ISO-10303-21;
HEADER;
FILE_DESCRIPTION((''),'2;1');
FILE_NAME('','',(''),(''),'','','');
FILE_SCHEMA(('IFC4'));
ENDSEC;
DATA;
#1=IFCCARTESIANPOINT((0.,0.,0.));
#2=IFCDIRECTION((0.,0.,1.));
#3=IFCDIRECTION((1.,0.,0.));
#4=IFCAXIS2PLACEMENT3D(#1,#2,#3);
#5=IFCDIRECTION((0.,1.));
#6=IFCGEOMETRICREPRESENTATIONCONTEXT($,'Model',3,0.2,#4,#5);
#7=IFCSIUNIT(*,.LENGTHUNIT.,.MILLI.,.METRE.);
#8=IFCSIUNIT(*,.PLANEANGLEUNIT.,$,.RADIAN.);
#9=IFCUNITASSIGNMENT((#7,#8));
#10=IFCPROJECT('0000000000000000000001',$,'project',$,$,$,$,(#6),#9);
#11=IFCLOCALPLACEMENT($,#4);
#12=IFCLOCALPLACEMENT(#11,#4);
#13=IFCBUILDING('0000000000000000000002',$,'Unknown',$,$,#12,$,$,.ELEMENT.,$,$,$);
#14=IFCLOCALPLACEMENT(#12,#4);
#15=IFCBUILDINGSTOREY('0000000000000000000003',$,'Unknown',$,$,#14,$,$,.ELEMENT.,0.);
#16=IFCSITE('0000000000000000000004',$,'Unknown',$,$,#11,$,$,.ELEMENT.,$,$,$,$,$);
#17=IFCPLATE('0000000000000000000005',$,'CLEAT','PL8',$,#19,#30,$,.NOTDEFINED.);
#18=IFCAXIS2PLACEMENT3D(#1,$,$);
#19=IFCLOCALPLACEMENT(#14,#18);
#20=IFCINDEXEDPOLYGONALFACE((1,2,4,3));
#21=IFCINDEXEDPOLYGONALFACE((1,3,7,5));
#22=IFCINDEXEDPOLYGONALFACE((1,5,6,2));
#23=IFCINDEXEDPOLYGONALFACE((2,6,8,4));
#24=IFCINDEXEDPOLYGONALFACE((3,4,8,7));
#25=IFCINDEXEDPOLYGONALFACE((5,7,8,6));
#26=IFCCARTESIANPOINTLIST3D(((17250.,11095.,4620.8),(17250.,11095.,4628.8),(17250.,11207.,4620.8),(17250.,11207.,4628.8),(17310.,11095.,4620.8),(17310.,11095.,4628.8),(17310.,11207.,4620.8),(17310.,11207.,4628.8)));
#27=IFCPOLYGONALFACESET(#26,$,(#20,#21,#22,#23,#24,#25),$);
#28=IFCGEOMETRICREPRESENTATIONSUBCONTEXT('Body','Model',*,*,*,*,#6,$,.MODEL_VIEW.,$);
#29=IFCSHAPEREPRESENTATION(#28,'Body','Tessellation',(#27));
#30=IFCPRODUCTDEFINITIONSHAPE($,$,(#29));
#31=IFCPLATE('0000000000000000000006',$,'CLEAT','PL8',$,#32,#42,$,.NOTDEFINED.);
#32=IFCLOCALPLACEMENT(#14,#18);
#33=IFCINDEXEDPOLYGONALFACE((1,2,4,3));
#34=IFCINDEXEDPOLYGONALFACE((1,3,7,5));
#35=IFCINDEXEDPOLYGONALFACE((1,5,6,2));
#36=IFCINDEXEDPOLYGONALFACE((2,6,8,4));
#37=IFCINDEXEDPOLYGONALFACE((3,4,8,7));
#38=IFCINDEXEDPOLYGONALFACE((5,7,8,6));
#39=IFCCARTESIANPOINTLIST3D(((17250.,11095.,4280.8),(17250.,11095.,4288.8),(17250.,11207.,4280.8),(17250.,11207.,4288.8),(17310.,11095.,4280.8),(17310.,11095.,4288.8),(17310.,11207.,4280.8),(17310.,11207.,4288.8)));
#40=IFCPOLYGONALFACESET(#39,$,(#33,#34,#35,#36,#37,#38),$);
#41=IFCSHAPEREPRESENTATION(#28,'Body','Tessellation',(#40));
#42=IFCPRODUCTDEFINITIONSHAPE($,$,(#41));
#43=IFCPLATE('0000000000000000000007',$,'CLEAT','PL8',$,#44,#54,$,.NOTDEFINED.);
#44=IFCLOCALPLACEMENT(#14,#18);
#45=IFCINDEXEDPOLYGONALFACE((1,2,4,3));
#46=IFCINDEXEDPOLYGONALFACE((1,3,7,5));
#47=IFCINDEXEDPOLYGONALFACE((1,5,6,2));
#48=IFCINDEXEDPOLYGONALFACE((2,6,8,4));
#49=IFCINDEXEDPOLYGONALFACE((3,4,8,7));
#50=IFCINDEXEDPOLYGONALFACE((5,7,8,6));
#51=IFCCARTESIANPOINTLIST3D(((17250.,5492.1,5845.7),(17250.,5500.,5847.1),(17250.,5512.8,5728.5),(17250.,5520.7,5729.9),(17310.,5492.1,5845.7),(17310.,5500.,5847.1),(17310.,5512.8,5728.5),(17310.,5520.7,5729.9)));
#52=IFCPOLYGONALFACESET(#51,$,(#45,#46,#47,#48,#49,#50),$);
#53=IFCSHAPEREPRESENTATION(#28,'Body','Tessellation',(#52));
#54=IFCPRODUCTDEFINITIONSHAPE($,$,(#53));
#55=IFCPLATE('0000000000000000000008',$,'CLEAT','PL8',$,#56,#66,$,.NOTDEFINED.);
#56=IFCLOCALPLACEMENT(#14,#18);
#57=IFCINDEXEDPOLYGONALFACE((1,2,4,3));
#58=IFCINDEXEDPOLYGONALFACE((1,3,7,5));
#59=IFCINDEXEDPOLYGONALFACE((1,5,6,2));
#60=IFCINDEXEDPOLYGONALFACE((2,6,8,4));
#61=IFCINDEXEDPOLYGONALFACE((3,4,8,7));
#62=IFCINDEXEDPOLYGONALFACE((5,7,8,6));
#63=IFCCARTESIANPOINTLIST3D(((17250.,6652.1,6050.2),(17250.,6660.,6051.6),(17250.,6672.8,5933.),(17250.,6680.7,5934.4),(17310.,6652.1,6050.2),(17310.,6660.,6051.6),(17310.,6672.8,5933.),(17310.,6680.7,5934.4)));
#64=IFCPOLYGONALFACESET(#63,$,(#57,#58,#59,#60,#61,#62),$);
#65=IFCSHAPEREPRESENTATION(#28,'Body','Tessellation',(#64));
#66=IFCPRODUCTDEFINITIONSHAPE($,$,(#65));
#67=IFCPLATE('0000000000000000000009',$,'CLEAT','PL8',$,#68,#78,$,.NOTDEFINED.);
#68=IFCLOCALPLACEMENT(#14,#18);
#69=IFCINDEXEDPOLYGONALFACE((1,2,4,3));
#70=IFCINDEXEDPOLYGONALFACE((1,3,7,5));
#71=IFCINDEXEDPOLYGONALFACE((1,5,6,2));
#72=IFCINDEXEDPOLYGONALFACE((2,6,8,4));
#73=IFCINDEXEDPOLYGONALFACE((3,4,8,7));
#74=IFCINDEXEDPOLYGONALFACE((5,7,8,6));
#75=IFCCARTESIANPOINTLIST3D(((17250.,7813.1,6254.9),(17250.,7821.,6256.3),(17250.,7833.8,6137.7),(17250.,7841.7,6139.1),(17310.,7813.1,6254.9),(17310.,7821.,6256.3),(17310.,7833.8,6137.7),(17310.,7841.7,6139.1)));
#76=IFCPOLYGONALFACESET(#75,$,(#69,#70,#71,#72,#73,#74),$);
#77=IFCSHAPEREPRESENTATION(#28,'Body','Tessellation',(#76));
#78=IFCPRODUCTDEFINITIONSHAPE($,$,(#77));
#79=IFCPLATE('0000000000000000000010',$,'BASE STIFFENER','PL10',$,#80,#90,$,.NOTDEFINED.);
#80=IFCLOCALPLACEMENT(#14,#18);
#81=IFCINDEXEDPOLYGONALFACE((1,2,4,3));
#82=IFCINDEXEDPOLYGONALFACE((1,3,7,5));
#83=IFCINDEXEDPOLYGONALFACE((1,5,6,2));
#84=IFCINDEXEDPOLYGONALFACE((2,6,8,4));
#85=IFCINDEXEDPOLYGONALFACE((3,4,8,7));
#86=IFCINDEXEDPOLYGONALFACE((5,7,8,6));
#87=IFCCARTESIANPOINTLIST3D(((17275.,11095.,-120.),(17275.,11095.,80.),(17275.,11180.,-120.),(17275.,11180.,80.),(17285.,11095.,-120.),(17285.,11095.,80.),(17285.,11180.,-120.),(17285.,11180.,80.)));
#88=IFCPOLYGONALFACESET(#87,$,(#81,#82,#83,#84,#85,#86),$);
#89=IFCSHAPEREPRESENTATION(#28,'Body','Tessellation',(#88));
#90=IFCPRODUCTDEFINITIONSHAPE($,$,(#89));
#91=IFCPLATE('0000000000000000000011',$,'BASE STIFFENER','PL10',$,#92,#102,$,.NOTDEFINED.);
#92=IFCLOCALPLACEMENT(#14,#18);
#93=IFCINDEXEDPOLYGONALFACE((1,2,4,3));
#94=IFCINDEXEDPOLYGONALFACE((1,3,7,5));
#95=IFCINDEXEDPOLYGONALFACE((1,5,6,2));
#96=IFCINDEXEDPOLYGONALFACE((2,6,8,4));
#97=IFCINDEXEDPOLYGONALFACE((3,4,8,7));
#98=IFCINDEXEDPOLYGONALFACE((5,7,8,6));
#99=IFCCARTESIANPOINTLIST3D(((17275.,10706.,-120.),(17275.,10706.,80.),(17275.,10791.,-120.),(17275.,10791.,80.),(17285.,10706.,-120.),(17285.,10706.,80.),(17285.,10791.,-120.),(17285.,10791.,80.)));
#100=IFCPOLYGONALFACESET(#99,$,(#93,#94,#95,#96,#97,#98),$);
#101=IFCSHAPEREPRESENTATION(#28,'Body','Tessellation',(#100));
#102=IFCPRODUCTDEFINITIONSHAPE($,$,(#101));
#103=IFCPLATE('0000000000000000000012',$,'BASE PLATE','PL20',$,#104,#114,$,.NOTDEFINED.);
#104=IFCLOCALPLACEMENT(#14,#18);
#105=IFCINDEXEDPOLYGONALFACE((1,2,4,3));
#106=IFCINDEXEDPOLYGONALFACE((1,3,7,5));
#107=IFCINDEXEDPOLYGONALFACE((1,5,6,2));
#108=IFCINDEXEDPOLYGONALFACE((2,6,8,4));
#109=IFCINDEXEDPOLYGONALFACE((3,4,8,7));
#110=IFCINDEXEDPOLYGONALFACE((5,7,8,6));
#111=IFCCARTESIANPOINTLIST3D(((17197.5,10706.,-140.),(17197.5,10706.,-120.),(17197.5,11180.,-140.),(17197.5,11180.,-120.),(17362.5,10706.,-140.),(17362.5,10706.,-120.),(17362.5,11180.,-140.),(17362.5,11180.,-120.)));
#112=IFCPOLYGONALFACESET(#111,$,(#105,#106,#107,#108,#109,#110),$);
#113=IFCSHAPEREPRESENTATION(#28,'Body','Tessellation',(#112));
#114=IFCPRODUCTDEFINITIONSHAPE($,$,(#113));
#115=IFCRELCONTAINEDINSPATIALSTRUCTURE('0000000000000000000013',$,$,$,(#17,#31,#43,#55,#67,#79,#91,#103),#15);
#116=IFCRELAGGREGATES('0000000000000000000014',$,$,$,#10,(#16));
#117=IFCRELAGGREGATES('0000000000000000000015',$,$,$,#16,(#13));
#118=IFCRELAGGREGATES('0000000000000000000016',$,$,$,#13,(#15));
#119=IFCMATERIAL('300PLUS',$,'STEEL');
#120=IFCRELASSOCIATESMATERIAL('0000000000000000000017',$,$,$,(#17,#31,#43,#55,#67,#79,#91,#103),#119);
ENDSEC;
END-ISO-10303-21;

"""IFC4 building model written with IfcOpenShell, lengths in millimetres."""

from ifc_helpers import new_model, si_unit, direction, frame, origin_with_axes, place, context, subcontext, project, spatial, line, indexed_curve, outline, extrude, material, element, save


model = new_model("IFC4")

# Units and contexts
model_context = context("Model", 3, precision=0.2, world=origin_with_axes(), true_north=direction((0.0, 1.0)))
body_context = subcontext(model_context, "Body", "Model", "MODEL_VIEW")
ifc_project = project(units=[si_unit("LENGTHUNIT", "METRE", prefix="MILLI"), si_unit("PLANEANGLEUNIT", "RADIAN")], contexts=[model_context])

# Site, building, storey
site_placement = place(None, origin_with_axes())
site = spatial("IfcSite", under=ifc_project, at=site_placement, Name="Unknown", CompositionType="ELEMENT")
building_placement = place(site_placement, origin_with_axes())
building = spatial("IfcBuilding", under=site, at=building_placement, Name="Unknown", CompositionType="ELEMENT")
storey_placement = place(building_placement, origin_with_axes())
storey = spatial("IfcBuildingStorey", under=building, at=storey_placement, Name="Unknown", CompositionType="ELEMENT", Elevation=0.0)

# Shared definitions
ifc_material_1 = material(Name="300PLUS", Category="STEEL")

# Plates
for number, where, z_axis, x_axis, name in (
    (1, (17250.0, 11095.0, 4624.8), (0.0, 0.0, 1.0), (1.0, 0.0, 0.0), "CLEAT"),
    (2, (17250.0, 11095.0, 4284.8), (0.0, 0.0, 1.0), (1.0, 0.0, 0.0), "CLEAT"),
):
    element("IfcPlate", number, at=place(storey_placement, frame(where, z_axis=z_axis, x_axis=x_axis)), inside=storey, material=ifc_material_1, Name=name, Description="PL8", PredefinedType="NOTDEFINED", context=body_context, shape_type="SolidModel", body=[
        extrude(outline(indexed_curve([(0.0, 0.0), (60.0, 0.0), (60.0, 112.0), (0.0, 112.0)], segments=[line(1, 2, 3, 4, 1)])), frame((0.0, 0.0, 4.0), z_axis=(0.0, 0.0, 1.0), x_axis=(1.0, 0.0, 0.0)), (0.0, 0.0, -1.0), 8.0),
    ])
for number, where, z_axis, x_axis, name in (
    (3, (17310.0, 5516.7, 5729.2), (0.0, 0.984758, 0.173929), (-1.0, 0.0, 0.0), "CLEAT"),
    (4, (17310.0, 6676.7, 5933.7), (0.0, 0.984758, 0.173929), (-1.0, 0.0, 0.0), "CLEAT"),
    (5, (17310.0, 7837.7, 6138.4), (0.0, 0.984758, 0.173929), (-1.0, 0.0, 0.0), "CLEAT"),
):
    element("IfcPlate", number, at=place(storey_placement, frame(where, z_axis=z_axis, x_axis=x_axis)), inside=storey, material=ifc_material_1, Name=name, Description="PL8", PredefinedType="NOTDEFINED", context=body_context, shape_type="SolidModel", body=[
        extrude(outline(indexed_curve([(0.0, 0.0), (60.0, 0.0), (60.0, 119.0), (0.0, 119.0)], segments=[line(1, 2, 3, 4, 1)])), frame((0.0, 0.0, 4.0), z_axis=(0.0, 0.0, 1.0), x_axis=(1.0, 0.0, 0.0)), (0.0, 0.0, -1.0), 8.0),
    ])
for number, where, z_axis, x_axis, name in (
    (6, (17280.0, 11095.0, -120.0), (1.0, 0.0, 0.0), (0.0, 1.0, 0.0), "BASE STIFFENER"),
    (7, (17280.0, 10706.0, -120.0), (1.0, 0.0, 0.0), (0.0, 1.0, 0.0), "BASE STIFFENER"),
):
    element("IfcPlate", number, at=place(storey_placement, frame(where, z_axis=z_axis, x_axis=x_axis)), inside=storey, material=ifc_material_1, Name=name, Description="PL10", PredefinedType="NOTDEFINED", context=body_context, shape_type="SolidModel", body=[
        extrude(outline(indexed_curve([(0.0, 0.0), (85.0, 0.0), (85.0, 200.0), (0.0, 200.0)], segments=[line(1, 2, 3, 4, 1)])), frame((0.0, 0.0, 5.0), z_axis=(0.0, 0.0, 1.0), x_axis=(1.0, 0.0, 0.0)), (0.0, 0.0, -1.0), 10.0),
    ])
plate_placement = place(storey_placement, frame((17197.5, 10706.0, -130.0), z_axis=(0.0, 0.0, 1.0), x_axis=(1.0, 0.0, 0.0)))
element("IfcPlate", 8, at=plate_placement, inside=storey, material=ifc_material_1, Name="BASE PLATE", Description="PL20", PredefinedType="NOTDEFINED", context=body_context, shape_type="SolidModel", body=[
    extrude(outline(indexed_curve([(0.0, 0.0), (165.0, 0.0), (165.0, 474.0), (0.0, 474.0)], segments=[line(1, 2, 3, 4, 1)])), frame((0.0, 0.0, 10.0), z_axis=(0.0, 0.0, 1.0), x_axis=(1.0, 0.0, 0.0)), (0.0, 0.0, -1.0), 20.0),
])

save(model, "model.ifc")
